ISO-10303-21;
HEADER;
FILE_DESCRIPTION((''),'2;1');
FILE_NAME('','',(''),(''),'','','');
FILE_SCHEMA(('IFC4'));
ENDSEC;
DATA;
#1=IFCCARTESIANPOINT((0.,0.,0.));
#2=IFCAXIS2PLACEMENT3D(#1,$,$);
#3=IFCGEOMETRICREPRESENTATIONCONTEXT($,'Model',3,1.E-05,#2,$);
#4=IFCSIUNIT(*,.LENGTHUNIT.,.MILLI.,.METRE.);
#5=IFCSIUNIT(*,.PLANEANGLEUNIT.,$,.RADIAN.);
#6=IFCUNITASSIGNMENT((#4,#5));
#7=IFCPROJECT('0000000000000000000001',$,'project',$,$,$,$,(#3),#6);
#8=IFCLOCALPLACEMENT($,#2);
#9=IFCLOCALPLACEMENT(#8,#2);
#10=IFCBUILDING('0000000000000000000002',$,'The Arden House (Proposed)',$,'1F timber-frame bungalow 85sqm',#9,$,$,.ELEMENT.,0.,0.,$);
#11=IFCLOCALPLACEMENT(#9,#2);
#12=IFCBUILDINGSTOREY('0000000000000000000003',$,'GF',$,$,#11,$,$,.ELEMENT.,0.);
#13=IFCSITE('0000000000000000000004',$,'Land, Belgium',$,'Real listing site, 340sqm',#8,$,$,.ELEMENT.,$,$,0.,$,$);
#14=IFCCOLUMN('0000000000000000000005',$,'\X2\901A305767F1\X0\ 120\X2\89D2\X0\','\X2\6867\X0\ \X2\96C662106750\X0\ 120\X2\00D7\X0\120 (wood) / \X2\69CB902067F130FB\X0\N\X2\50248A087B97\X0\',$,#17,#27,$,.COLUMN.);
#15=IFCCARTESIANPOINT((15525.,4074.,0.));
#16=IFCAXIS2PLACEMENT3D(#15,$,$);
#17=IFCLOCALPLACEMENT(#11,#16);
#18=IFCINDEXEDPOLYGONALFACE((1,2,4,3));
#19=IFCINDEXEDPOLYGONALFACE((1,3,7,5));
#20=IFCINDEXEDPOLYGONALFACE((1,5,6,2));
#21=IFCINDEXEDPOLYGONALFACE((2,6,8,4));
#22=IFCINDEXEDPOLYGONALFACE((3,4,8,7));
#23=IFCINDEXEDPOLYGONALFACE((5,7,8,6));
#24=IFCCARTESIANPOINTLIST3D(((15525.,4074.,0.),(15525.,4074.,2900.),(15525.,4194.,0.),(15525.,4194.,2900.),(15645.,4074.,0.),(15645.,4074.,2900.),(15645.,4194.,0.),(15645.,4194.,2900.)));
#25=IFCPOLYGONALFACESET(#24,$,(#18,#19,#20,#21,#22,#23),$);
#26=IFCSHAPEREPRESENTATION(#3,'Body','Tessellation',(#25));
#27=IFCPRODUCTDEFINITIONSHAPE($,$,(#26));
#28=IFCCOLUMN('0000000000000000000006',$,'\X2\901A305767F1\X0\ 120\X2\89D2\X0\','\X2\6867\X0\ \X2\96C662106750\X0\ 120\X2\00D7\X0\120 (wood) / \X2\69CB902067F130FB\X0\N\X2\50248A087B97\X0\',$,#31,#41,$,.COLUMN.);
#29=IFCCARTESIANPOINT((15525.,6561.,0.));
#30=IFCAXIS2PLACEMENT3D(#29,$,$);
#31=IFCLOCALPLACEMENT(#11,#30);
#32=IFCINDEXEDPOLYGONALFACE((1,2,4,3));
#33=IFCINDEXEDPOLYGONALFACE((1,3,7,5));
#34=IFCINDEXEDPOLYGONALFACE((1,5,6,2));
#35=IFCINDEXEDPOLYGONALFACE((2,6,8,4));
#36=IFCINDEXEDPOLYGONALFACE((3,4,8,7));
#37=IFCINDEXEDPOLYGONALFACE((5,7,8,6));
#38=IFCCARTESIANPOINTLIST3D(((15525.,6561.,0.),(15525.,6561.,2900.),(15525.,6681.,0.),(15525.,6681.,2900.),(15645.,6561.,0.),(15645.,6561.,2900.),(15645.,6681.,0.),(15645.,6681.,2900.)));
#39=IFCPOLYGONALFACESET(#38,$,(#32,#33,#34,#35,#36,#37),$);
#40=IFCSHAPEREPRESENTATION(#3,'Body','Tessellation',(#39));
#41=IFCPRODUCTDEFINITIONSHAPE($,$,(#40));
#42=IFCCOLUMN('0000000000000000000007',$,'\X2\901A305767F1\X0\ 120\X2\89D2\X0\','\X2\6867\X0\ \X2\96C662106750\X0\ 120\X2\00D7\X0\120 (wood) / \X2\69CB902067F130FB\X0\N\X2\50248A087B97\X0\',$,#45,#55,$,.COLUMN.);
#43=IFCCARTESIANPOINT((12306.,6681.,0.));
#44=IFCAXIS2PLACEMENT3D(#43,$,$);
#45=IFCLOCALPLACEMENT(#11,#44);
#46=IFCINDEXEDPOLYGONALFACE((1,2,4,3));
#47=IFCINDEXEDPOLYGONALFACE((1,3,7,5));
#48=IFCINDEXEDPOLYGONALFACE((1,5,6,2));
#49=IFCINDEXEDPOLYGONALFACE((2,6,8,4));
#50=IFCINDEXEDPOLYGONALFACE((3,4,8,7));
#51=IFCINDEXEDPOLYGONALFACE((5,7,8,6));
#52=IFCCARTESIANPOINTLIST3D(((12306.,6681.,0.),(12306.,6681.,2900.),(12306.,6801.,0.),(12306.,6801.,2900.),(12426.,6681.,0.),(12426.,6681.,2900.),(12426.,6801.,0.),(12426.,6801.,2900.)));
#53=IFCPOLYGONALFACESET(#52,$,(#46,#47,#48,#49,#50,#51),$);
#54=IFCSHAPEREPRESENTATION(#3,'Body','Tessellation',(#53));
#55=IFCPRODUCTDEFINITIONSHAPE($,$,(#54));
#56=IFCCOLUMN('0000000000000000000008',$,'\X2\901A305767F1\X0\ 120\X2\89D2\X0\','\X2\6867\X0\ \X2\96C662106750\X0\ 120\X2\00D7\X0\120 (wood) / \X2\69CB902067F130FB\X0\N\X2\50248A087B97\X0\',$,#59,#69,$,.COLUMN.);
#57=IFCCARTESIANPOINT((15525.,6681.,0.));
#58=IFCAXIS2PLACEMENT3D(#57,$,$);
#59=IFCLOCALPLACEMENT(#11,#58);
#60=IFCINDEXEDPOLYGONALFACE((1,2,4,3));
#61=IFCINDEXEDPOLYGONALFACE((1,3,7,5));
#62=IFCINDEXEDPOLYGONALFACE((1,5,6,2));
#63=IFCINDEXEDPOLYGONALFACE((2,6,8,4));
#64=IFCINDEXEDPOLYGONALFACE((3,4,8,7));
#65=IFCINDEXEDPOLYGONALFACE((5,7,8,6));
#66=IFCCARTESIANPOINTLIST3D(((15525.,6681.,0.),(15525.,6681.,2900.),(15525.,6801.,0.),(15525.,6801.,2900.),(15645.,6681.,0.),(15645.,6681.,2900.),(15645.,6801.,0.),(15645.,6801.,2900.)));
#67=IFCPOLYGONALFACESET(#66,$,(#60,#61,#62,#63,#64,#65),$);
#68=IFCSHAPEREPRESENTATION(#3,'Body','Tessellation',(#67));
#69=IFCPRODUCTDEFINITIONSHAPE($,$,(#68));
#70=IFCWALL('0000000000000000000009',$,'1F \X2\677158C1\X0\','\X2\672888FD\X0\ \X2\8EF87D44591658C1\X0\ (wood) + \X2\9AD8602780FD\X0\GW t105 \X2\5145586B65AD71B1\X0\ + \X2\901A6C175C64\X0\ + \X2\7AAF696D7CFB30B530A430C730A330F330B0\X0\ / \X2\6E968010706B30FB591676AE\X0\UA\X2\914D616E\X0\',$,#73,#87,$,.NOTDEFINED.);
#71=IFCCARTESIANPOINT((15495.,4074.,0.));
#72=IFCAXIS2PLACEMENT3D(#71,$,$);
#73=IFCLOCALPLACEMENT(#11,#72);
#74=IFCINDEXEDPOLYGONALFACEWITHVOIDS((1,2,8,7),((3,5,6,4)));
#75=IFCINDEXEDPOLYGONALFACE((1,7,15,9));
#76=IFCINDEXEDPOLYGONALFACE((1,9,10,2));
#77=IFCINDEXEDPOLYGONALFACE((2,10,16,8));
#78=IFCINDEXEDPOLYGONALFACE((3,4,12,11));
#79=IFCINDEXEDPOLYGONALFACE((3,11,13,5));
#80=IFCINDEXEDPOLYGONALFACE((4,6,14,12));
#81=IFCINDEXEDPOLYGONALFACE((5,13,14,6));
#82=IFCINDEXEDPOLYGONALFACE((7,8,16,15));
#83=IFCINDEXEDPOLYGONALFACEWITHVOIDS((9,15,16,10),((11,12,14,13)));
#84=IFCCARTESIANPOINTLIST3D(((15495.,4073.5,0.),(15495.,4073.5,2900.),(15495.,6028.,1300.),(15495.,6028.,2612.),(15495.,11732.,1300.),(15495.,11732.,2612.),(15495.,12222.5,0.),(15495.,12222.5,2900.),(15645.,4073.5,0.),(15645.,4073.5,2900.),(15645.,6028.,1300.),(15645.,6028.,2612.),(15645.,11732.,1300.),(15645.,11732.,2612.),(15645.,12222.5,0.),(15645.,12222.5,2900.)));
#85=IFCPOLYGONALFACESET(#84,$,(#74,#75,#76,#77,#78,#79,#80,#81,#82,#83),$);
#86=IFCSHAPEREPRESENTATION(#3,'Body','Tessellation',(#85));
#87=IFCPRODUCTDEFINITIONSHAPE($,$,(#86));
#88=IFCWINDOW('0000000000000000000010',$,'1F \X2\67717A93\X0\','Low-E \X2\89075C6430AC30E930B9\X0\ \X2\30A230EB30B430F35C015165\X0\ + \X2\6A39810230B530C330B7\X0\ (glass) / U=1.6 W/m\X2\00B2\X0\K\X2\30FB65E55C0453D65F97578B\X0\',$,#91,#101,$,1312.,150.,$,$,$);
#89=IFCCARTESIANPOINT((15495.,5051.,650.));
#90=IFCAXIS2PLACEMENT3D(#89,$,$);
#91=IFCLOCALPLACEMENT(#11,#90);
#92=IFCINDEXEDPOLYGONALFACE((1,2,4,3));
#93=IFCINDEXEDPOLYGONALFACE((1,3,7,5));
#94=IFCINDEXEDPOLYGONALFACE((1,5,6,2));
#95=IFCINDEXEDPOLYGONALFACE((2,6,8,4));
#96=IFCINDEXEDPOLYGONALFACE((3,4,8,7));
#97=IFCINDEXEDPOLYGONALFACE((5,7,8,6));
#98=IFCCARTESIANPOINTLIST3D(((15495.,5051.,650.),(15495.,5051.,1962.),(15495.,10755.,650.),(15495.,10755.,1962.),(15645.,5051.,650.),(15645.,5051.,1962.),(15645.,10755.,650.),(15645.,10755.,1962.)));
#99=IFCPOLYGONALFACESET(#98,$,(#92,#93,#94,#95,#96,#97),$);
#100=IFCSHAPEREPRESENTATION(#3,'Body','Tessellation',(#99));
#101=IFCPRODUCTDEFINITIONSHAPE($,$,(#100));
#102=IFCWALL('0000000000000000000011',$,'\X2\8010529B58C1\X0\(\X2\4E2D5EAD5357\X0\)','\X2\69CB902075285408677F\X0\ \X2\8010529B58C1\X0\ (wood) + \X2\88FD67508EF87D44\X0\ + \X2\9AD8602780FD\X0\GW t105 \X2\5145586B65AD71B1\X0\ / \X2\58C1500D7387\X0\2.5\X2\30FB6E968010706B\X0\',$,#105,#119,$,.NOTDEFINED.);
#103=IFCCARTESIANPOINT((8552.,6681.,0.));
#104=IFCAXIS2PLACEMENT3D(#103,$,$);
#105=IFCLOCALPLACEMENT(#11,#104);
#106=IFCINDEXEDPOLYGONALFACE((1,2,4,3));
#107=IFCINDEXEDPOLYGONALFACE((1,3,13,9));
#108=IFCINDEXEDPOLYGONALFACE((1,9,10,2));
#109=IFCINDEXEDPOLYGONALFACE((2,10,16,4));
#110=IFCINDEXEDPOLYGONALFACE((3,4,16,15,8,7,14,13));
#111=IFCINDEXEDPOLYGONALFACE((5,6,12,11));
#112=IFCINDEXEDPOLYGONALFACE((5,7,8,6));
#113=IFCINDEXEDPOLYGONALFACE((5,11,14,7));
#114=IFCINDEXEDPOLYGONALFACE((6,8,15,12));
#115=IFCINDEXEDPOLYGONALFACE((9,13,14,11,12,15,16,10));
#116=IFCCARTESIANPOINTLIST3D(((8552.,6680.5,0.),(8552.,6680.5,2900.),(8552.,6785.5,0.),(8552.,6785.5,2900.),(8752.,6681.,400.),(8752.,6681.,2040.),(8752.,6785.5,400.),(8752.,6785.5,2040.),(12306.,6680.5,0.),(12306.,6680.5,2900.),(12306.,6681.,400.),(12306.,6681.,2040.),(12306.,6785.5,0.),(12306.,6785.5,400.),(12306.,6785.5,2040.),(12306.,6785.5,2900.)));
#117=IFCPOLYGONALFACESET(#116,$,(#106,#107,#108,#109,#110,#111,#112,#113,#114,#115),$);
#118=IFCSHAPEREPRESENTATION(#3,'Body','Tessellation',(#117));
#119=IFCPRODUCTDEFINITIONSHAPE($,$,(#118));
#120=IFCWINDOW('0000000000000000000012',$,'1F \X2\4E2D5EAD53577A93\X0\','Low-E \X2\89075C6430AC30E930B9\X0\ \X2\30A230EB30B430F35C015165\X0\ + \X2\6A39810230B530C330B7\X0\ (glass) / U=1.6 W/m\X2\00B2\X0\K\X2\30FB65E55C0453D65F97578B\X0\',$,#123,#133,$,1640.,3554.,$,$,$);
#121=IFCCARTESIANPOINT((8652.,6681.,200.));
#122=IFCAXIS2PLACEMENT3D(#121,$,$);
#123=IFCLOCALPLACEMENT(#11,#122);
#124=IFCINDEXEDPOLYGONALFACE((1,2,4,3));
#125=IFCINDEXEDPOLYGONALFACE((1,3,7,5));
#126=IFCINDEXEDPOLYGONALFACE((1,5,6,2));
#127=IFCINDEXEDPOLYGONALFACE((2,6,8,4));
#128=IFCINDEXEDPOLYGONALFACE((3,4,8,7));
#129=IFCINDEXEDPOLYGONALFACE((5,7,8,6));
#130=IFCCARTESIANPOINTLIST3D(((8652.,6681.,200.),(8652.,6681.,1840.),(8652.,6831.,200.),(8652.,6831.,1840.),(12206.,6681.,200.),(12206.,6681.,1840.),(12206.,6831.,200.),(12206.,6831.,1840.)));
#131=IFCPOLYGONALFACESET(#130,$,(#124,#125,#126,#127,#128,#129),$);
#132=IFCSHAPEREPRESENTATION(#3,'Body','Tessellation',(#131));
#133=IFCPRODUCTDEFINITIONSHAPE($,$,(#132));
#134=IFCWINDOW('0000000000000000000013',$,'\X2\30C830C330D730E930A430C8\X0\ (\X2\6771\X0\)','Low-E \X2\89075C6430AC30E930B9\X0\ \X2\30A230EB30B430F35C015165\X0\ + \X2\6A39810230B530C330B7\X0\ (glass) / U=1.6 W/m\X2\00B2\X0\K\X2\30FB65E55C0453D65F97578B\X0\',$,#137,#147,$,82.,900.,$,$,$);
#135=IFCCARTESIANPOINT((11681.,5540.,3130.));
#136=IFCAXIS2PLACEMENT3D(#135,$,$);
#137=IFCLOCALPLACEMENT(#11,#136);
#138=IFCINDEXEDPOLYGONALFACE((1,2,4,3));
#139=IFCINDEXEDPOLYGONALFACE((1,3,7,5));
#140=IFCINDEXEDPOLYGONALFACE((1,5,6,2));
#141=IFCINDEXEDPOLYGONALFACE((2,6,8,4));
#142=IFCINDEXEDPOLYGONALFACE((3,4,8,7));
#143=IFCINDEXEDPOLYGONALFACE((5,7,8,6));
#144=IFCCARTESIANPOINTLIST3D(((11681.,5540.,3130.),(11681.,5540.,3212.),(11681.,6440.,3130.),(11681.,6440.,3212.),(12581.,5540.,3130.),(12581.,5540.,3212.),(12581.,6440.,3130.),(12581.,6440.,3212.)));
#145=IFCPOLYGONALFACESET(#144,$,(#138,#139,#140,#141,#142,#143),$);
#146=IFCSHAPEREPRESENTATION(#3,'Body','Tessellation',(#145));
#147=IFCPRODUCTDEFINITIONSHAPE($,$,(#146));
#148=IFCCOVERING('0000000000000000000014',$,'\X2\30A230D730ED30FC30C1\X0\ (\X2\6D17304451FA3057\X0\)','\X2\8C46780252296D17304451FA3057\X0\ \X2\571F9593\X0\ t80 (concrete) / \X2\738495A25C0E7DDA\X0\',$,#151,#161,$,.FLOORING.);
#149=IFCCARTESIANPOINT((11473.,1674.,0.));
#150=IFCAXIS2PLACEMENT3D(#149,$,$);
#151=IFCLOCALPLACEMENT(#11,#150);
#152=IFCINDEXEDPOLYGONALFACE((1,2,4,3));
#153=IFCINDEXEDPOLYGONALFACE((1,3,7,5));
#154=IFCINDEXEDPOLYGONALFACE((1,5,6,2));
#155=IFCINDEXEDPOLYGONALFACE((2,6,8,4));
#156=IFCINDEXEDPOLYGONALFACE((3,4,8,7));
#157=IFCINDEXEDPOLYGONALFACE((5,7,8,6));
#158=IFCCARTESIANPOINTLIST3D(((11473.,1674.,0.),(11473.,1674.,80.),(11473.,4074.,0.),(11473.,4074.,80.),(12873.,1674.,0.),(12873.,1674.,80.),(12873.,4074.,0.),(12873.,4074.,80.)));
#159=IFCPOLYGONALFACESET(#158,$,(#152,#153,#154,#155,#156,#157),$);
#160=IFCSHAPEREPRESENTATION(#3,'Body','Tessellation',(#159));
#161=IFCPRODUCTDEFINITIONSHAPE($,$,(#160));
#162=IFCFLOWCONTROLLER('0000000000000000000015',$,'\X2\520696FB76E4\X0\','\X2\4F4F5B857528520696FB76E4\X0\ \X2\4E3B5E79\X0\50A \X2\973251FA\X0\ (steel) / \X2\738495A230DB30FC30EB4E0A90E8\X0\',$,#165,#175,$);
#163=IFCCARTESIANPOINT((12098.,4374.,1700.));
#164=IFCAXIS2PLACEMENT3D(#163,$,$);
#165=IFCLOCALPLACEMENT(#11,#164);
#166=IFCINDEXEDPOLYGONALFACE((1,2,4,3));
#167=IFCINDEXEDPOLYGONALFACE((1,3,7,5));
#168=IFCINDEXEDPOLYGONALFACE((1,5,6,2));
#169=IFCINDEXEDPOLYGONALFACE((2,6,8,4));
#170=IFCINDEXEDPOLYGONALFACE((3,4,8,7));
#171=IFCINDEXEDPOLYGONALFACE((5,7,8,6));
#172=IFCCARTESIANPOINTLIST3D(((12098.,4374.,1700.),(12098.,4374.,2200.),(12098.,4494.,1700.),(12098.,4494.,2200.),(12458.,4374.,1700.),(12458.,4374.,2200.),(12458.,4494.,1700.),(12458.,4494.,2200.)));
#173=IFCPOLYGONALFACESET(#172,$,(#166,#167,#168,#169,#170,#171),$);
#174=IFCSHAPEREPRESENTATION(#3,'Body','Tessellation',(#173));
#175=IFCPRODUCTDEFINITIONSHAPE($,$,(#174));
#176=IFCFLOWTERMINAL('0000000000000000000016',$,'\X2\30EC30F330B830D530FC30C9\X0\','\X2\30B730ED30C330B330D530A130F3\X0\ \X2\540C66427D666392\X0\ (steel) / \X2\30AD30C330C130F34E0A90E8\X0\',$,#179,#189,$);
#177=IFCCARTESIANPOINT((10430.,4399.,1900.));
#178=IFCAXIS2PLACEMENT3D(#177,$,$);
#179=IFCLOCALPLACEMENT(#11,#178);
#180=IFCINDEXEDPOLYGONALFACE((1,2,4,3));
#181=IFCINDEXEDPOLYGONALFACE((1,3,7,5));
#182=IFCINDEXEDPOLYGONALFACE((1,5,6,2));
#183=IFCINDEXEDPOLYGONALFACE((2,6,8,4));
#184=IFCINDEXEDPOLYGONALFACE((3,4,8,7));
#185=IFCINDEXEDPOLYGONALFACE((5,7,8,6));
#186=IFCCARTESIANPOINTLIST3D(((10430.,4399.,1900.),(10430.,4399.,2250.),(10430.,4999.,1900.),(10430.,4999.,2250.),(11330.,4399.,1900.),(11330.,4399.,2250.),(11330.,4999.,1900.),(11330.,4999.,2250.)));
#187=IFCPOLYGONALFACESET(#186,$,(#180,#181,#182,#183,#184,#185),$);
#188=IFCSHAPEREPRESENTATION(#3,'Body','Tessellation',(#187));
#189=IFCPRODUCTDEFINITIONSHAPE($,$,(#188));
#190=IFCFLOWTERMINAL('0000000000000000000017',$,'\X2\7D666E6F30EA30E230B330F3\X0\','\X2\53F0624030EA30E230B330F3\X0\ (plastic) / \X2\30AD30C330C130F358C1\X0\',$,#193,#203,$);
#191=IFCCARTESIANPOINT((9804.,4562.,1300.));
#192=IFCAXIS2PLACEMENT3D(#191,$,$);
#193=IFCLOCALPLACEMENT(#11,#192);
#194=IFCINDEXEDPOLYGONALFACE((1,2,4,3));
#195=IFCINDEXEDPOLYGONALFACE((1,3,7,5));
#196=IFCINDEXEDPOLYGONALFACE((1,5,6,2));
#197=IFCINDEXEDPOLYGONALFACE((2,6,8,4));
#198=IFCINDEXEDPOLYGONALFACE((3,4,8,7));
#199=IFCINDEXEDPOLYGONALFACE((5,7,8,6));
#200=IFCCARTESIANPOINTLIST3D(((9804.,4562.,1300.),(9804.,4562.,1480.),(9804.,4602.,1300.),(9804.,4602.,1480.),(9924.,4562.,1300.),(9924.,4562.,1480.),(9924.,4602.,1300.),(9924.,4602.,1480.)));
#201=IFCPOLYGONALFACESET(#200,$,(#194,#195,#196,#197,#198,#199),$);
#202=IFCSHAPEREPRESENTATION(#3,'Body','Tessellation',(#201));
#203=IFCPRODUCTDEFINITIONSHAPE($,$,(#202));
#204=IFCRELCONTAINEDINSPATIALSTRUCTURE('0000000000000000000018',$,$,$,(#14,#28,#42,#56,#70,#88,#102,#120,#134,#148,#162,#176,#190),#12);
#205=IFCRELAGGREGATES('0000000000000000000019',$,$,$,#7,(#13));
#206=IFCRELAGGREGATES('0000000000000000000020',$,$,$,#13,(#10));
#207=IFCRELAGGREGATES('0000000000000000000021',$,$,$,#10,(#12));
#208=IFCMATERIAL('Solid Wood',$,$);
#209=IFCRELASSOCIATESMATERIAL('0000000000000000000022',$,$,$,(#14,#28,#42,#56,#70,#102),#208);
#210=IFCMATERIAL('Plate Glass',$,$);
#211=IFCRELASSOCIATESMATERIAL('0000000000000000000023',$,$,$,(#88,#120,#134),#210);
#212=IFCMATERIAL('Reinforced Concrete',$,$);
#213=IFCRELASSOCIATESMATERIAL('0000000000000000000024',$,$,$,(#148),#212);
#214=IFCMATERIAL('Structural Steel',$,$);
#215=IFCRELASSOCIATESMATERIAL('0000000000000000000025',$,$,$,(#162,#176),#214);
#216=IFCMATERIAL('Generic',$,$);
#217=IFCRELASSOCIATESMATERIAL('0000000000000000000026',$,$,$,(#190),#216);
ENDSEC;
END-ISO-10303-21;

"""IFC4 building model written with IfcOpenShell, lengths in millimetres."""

from ifc_helpers import new_model, si_unit, frame, frame_2d, origin, place, context, project, spatial, rectangle, extrude, material, element, fill, save


model = new_model("IFC4")

# Units and contexts
model_context = context("Model", 3, precision=1e-05, world=origin())
ifc_project = project(units=[si_unit("LENGTHUNIT", "METRE", prefix="MILLI"), si_unit("PLANEANGLEUNIT", "RADIAN")], contexts=[model_context])

# Site, building, storey
site_placement = place(None, origin())
site = spatial("IfcSite", under=ifc_project, at=site_placement, Name="Land, Belgium", ObjectType="Real listing site, 340sqm", CompositionType="ELEMENT", RefElevation=0.0)
building_placement = place(site_placement, origin())
building = spatial("IfcBuilding", under=site, at=building_placement, Name="The Arden House (Proposed)", ObjectType="1F timber-frame bungalow 85sqm", CompositionType="ELEMENT", ElevationOfRefHeight=0.0, ElevationOfTerrain=0.0)
storey_placement = place(building_placement, origin())
storey = spatial("IfcBuildingStorey", under=building, at=storey_placement, Name="GF", CompositionType="ELEMENT", Elevation=0.0)

# Columns
ifc_material_1 = material(Name="Solid Wood")
column_1_placement = place(storey_placement, frame((15525.0, 4074.0, 0.0)))
element("IfcColumn", 1, at=column_1_placement, inside=storey, material=ifc_material_1, Name="通し柱 120角", Description="桧 集成材 120×120 (wood) / 構造柱・N値計算", PredefinedType="COLUMN", context=model_context, shape_type="SweptSolid", body=[
    extrude(rectangle(XDim=120.0, YDim=120.0, at=frame_2d((60.0, 60.0))), frame((15525.0, 4074.0, 0.0)), (0.0, 0.0, 1.0), 2900.0),
])
column_2_placement = place(storey_placement, frame((15525.0, 6561.0, 0.0)))
element("IfcColumn", 2, at=column_2_placement, inside=storey, material=ifc_material_1, Name="通し柱 120角", Description="桧 集成材 120×120 (wood) / 構造柱・N値計算", PredefinedType="COLUMN", context=model_context, shape_type="SweptSolid", body=[
    extrude(rectangle(XDim=120.0, YDim=120.0, at=frame_2d((60.0, 60.0))), frame((15525.0, 6561.0, 0.0)), (0.0, 0.0, 1.0), 2900.0),
])
column_3_placement = place(storey_placement, frame((12306.0, 6681.0, 0.0)))
element("IfcColumn", 3, at=column_3_placement, inside=storey, material=ifc_material_1, Name="通し柱 120角", Description="桧 集成材 120×120 (wood) / 構造柱・N値計算", PredefinedType="COLUMN", context=model_context, shape_type="SweptSolid", body=[
    extrude(rectangle(XDim=120.0, YDim=120.0, at=frame_2d((60.0, 60.0))), frame((12306.0, 6681.0, 0.0)), (0.0, 0.0, 1.0), 2900.0),
])
column_4_placement = place(storey_placement, frame((15525.0, 6681.0, 0.0)))
element("IfcColumn", 4, at=column_4_placement, inside=storey, material=ifc_material_1, Name="通し柱 120角", Description="桧 集成材 120×120 (wood) / 構造柱・N値計算", PredefinedType="COLUMN", context=model_context, shape_type="SweptSolid", body=[
    extrude(rectangle(XDim=120.0, YDim=120.0, at=frame_2d((60.0, 60.0))), frame((15525.0, 6681.0, 0.0)), (0.0, 0.0, 1.0), 2900.0),
])

# Walls, openings, windows
wall_1_placement = place(storey_placement, frame((15495.0, 4074.0, 0.0)))
wall_1 = element("IfcWall", 5, at=wall_1_placement, inside=storey, material=ifc_material_1, Name="1F 東壁", Description="木製 軸組外壁 (wood) + 高性能GW t105 充填断熱 + 通気層 + 窯業系サイディング / 準耐火・外皮UA配慮", PredefinedType="NOTDEFINED", context=model_context, shape_type="SweptSolid", body=[
    extrude(rectangle(XDim=150.0, YDim=8149.0, at=frame_2d((75.0, 4074.0))), frame((15495.0, 4074.0, 0.0)), (0.0, 0.0, 1.0), 2900.0),
])
opening_1_placement = place(storey_placement, frame((15495.0, 5051.0, 650.0)))
opening_1 = element("IfcOpeningElement", 6, at=opening_1_placement, cuts=wall_1, PredefinedType="NOTDEFINED", context=model_context, shape_type="SweptSolid", body=[
    extrude(rectangle(XDim=150.0, YDim=5704.0, at=frame_2d((75.0, 2852.0))), frame((15495.0, 5051.0, 650.0)), (0.0, 0.0, 1.0), 1312.0),
])
ifc_material_2 = material(Name="Plate Glass")
window_1_placement = place(storey_placement, frame((15495.0, 5051.0, 650.0)))
window_1 = element("IfcWindow", 7, at=window_1_placement, inside=storey, material=ifc_material_2, Name="1F 東窓", Description="Low-E 複層ガラス アルゴン封入 + 樹脂サッシ (glass) / U=1.6 W/m²K・日射取得型", OverallHeight=1312.0, OverallWidth=150.0, context=model_context, shape_type="SweptSolid", body=[
    extrude(rectangle(XDim=150.0, YDim=5704.0, at=frame_2d((75.0, 2852.0))), frame((15495.0, 5051.0, 650.0)), (0.0, 0.0, 1.0), 1312.0),
])
fill(opening_1, window_1)
wall_2_placement = place(storey_placement, frame((8552.0, 6681.0, 0.0)))
wall_2 = element("IfcWall", 8, at=wall_2_placement, inside=storey, material=ifc_material_1, Name="耐力壁(中庭南)", Description="構造用合板 耐力壁 (wood) + 製材軸組 + 高性能GW t105 充填断熱 / 壁倍率2.5・準耐火", PredefinedType="NOTDEFINED", context=model_context, shape_type="SweptSolid", body=[
    extrude(rectangle(XDim=3754.0, YDim=105.0, at=frame_2d((1877.0, 52.0))), frame((8552.0, 6681.0, 0.0)), (0.0, 0.0, 1.0), 2900.0),
])
opening_2_placement = place(storey_placement, frame((8652.0, 6681.0, 200.0)))
opening_2 = element("IfcOpeningElement", 9, at=opening_2_placement, cuts=wall_2, PredefinedType="NOTDEFINED", context=model_context, shape_type="SweptSolid", body=[
    extrude(rectangle(XDim=3554.0, YDim=150.0, at=frame_2d((1777.0, 75.0))), frame((8652.0, 6681.0, 200.0)), (0.0, 0.0, 1.0), 1640.0),
])
window_2_placement = place(storey_placement, frame((8652.0, 6681.0, 200.0)))
window_2 = element("IfcWindow", 10, at=window_2_placement, inside=storey, material=ifc_material_2, Name="1F 中庭南窓", Description="Low-E 複層ガラス アルゴン封入 + 樹脂サッシ (glass) / U=1.6 W/m²K・日射取得型", OverallHeight=1640.0, OverallWidth=3554.0, context=model_context, shape_type="SweptSolid", body=[
    extrude(rectangle(XDim=3554.0, YDim=150.0, at=frame_2d((1777.0, 75.0))), frame((8652.0, 6681.0, 200.0)), (0.0, 0.0, 1.0), 1640.0),
])
fill(opening_2, window_2)

# Window
window_3_placement = place(storey_placement, frame((11681.0, 5540.0, 3130.0)))
element("IfcWindow", 11, at=window_3_placement, inside=storey, material=ifc_material_2, Name="トップライト (東)", Description="Low-E 複層ガラス アルゴン封入 + 樹脂サッシ (glass) / U=1.6 W/m²K・日射取得型", OverallHeight=82.0, OverallWidth=900.0, context=model_context, shape_type="SweptSolid", body=[
    extrude(rectangle(XDim=900.0, YDim=900.0, at=frame_2d((450.0, 450.0))), frame((11681.0, 5540.0, 3130.0)), (0.0, 0.0, 1.0), 82.0),
])

# Shared definitions
ifc_material_3 = material(Name="Structural Steel")

# Covering
ifc_material_4 = material(Name="Reinforced Concrete")
covering_placement = place(storey_placement, frame((11473.0, 1674.0, 0.0)))
element("IfcCovering", 12, at=covering_placement, inside=storey, material=ifc_material_4, Name="アプローチ (洗い出し)", Description="豆砂利洗い出し 土間 t80 (concrete) / 玄関導線", PredefinedType="FLOORING", context=model_context, shape_type="SweptSolid", body=[
    extrude(rectangle(XDim=1400.0, YDim=2400.0, at=frame_2d((700.0, 1200.0))), frame((11473.0, 1674.0, 0.0)), (0.0, 0.0, 1.0), 80.0),
])

# Flow controller
flow_controller_placement = place(storey_placement, frame((12098.0, 4374.0, 1700.0)))
element("IfcFlowController", 13, at=flow_controller_placement, inside=storey, material=ifc_material_3, Name="分電盤", Description="住宅用分電盤 主幹50A 露出 (steel) / 玄関ホール上部", context=model_context, shape_type="SweptSolid", body=[
    extrude(rectangle(XDim=360.0, YDim=120.0, at=frame_2d((180.0, 60.0))), frame((12098.0, 4374.0, 1700.0)), (0.0, 0.0, 1.0), 500.0),
])

# Flow terminals
flow_terminal_1_placement = place(storey_placement, frame((10430.0, 4399.0, 1900.0)))
element("IfcFlowTerminal", 14, at=flow_terminal_1_placement, inside=storey, material=ifc_material_3, Name="レンジフード", Description="シロッコファン 同時給排 (steel) / キッチン上部", context=model_context, shape_type="SweptSolid", body=[
    extrude(rectangle(XDim=900.0, YDim=600.0, at=frame_2d((450.0, 300.0))), frame((10430.0, 4399.0, 1900.0)), (0.0, 0.0, 1.0), 350.0),
])
ifc_material_5 = material(Name="Generic")
flow_terminal_2_placement = place(storey_placement, frame((9804.0, 4562.0, 1300.0)))
element("IfcFlowTerminal", 15, at=flow_terminal_2_placement, inside=storey, material=ifc_material_5, Name="給湯リモコン", Description="台所リモコン (plastic) / キッチン壁", context=model_context, shape_type="SweptSolid", body=[
    extrude(rectangle(XDim=120.0, YDim=40.0, at=frame_2d((60.0, 20.0))), frame((9804.0, 4562.0, 1300.0)), (0.0, 0.0, 1.0), 180.0),
])

save(model, "model.ifc")
